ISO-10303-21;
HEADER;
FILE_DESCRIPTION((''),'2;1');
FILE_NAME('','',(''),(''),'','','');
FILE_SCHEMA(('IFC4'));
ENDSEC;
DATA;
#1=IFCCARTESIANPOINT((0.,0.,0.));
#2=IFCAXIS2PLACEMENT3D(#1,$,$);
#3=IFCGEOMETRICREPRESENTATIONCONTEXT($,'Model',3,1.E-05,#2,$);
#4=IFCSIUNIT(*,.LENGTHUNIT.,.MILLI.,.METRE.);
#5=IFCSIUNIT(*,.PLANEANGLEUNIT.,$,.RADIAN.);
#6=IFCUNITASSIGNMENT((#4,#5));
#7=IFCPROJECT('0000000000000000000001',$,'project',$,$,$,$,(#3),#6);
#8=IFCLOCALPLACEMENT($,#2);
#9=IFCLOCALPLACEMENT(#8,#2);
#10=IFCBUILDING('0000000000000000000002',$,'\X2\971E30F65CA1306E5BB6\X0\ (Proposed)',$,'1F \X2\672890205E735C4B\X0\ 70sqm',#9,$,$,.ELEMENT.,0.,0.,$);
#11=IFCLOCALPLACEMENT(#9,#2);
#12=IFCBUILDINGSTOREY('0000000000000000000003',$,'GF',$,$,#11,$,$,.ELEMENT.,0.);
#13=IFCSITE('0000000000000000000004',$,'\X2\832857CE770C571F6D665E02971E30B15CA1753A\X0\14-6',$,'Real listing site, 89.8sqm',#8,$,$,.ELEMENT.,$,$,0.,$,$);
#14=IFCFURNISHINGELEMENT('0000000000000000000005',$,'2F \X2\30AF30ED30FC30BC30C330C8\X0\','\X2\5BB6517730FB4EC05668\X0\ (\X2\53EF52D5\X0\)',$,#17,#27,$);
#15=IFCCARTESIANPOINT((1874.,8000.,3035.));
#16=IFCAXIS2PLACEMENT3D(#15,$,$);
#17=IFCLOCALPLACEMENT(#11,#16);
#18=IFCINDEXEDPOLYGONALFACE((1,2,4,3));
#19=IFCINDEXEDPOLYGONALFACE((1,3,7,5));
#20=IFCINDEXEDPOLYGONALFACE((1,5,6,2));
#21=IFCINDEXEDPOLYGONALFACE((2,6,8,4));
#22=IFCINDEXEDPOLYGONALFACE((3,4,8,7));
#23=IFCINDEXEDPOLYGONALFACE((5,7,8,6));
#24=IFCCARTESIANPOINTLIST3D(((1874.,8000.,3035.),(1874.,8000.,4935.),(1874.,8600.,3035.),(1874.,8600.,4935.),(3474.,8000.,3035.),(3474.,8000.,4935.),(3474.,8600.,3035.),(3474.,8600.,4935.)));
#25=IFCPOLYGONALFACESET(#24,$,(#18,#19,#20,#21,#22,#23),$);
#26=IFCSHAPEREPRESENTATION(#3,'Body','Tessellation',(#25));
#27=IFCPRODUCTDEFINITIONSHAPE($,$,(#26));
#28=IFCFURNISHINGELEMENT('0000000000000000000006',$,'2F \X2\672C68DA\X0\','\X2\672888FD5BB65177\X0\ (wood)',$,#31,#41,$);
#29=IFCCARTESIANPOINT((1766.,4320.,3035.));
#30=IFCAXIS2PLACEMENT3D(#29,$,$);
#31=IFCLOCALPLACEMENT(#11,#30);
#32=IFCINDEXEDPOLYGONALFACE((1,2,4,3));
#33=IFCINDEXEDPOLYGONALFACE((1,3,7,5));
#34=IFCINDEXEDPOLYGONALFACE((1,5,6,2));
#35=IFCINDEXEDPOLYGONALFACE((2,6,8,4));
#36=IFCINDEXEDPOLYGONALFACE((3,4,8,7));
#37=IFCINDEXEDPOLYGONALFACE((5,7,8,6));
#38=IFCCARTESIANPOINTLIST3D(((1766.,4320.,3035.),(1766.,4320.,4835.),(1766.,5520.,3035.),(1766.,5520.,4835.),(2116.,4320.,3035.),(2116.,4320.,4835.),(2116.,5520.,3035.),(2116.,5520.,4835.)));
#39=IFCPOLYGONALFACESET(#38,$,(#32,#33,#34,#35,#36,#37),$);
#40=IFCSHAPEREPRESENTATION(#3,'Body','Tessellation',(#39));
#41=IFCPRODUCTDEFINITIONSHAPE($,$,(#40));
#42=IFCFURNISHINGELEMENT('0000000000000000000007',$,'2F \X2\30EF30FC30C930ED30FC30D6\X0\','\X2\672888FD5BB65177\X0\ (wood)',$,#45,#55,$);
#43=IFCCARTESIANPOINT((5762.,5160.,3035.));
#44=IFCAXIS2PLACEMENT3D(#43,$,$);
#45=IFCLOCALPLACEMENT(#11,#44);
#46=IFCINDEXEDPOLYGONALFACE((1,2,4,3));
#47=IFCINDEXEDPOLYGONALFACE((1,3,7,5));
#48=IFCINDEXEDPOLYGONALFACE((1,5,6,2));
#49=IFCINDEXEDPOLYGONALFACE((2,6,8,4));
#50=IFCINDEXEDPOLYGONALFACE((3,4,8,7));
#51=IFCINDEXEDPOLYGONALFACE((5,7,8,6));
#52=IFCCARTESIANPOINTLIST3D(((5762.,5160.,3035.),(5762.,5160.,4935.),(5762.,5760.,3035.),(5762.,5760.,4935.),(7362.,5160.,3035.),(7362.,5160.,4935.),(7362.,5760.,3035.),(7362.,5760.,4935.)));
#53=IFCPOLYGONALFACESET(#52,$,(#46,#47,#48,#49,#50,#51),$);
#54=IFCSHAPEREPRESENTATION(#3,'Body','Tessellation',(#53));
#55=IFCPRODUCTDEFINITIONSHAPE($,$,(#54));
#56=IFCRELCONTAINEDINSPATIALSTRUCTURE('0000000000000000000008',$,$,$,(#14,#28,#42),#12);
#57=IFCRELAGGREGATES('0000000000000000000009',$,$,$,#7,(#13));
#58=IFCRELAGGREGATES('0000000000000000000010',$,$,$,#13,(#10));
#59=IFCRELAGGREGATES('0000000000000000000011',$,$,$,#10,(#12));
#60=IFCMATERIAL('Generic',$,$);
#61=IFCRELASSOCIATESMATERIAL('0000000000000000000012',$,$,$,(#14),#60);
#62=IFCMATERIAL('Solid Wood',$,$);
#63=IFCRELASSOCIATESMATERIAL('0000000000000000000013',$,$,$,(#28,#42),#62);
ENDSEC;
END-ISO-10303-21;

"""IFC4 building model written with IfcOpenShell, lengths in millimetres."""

from ifc_helpers import new_model, si_unit, frame, frame_2d, origin, place, context, project, spatial, rectangle, extrude, material, element, save


model = new_model("IFC4")

# Units and contexts
model_context = context("Model", 3, precision=1e-05, world=origin())
ifc_project = project(units=[si_unit("LENGTHUNIT", "METRE", prefix="MILLI"), si_unit("PLANEANGLEUNIT", "RADIAN")], contexts=[model_context])

# Site, building, storey
site_placement = place(None, origin())
site = spatial("IfcSite", under=ifc_project, at=site_placement, Name="茨城県土浦市霞ケ岡町14-6", ObjectType="Real listing site, 89.8sqm", CompositionType="ELEMENT", RefElevation=0.0)
building_placement = place(site_placement, origin())
building = spatial("IfcBuilding", under=site, at=building_placement, Name="霞ヶ岡の家 (Proposed)", ObjectType="1F 木造平屋 70sqm", CompositionType="ELEMENT", ElevationOfRefHeight=0.0, ElevationOfTerrain=0.0)
storey_placement = place(building_placement, origin())
storey = spatial("IfcBuildingStorey", under=building, at=storey_placement, Name="GF", CompositionType="ELEMENT", Elevation=0.0)

# Shared definitions
ifc_material_1 = material(Name="Solid Wood")

# Shared definitions
ifc_material_2 = material(Name="Generic")

# Furnishing elements
furnishing_1_placement = place(storey_placement, frame((1874.0, 8000.0, 3035.0)))
element("IfcFurnishingElement", 1, at=furnishing_1_placement, inside=storey, material=ifc_material_2, Name="2F クローゼット", Description="家具・什器 (可動)", context=model_context, shape_type="SweptSolid", body=[
    extrude(rectangle(XDim=1600.0, YDim=600.0, at=frame_2d((800.0, 300.0))), frame((1874.0, 8000.0, 3035.0)), (0.0, 0.0, 1.0), 1900.0),
])
furnishing_2_placement = place(storey_placement, frame((1766.0, 4320.0, 3035.0)))
element("IfcFurnishingElement", 2, at=furnishing_2_placement, inside=storey, material=ifc_material_1, Name="2F 本棚", Description="木製家具 (wood)", context=model_context, shape_type="SweptSolid", body=[
    extrude(rectangle(XDim=350.0, YDim=1200.0, at=frame_2d((175.0, 600.0))), frame((1766.0, 4320.0, 3035.0)), (0.0, 0.0, 1.0), 1800.0),
])
furnishing_3_placement = place(storey_placement, frame((5762.0, 5160.0, 3035.0)))
element("IfcFurnishingElement", 3, at=furnishing_3_placement, inside=storey, material=ifc_material_1, Name="2F ワードローブ", Description="木製家具 (wood)", context=model_context, shape_type="SweptSolid", body=[
    extrude(rectangle(XDim=1600.0, YDim=600.0, at=frame_2d((800.0, 300.0))), frame((5762.0, 5160.0, 3035.0)), (0.0, 0.0, 1.0), 1900.0),
])

save(model, "model.ifc")
